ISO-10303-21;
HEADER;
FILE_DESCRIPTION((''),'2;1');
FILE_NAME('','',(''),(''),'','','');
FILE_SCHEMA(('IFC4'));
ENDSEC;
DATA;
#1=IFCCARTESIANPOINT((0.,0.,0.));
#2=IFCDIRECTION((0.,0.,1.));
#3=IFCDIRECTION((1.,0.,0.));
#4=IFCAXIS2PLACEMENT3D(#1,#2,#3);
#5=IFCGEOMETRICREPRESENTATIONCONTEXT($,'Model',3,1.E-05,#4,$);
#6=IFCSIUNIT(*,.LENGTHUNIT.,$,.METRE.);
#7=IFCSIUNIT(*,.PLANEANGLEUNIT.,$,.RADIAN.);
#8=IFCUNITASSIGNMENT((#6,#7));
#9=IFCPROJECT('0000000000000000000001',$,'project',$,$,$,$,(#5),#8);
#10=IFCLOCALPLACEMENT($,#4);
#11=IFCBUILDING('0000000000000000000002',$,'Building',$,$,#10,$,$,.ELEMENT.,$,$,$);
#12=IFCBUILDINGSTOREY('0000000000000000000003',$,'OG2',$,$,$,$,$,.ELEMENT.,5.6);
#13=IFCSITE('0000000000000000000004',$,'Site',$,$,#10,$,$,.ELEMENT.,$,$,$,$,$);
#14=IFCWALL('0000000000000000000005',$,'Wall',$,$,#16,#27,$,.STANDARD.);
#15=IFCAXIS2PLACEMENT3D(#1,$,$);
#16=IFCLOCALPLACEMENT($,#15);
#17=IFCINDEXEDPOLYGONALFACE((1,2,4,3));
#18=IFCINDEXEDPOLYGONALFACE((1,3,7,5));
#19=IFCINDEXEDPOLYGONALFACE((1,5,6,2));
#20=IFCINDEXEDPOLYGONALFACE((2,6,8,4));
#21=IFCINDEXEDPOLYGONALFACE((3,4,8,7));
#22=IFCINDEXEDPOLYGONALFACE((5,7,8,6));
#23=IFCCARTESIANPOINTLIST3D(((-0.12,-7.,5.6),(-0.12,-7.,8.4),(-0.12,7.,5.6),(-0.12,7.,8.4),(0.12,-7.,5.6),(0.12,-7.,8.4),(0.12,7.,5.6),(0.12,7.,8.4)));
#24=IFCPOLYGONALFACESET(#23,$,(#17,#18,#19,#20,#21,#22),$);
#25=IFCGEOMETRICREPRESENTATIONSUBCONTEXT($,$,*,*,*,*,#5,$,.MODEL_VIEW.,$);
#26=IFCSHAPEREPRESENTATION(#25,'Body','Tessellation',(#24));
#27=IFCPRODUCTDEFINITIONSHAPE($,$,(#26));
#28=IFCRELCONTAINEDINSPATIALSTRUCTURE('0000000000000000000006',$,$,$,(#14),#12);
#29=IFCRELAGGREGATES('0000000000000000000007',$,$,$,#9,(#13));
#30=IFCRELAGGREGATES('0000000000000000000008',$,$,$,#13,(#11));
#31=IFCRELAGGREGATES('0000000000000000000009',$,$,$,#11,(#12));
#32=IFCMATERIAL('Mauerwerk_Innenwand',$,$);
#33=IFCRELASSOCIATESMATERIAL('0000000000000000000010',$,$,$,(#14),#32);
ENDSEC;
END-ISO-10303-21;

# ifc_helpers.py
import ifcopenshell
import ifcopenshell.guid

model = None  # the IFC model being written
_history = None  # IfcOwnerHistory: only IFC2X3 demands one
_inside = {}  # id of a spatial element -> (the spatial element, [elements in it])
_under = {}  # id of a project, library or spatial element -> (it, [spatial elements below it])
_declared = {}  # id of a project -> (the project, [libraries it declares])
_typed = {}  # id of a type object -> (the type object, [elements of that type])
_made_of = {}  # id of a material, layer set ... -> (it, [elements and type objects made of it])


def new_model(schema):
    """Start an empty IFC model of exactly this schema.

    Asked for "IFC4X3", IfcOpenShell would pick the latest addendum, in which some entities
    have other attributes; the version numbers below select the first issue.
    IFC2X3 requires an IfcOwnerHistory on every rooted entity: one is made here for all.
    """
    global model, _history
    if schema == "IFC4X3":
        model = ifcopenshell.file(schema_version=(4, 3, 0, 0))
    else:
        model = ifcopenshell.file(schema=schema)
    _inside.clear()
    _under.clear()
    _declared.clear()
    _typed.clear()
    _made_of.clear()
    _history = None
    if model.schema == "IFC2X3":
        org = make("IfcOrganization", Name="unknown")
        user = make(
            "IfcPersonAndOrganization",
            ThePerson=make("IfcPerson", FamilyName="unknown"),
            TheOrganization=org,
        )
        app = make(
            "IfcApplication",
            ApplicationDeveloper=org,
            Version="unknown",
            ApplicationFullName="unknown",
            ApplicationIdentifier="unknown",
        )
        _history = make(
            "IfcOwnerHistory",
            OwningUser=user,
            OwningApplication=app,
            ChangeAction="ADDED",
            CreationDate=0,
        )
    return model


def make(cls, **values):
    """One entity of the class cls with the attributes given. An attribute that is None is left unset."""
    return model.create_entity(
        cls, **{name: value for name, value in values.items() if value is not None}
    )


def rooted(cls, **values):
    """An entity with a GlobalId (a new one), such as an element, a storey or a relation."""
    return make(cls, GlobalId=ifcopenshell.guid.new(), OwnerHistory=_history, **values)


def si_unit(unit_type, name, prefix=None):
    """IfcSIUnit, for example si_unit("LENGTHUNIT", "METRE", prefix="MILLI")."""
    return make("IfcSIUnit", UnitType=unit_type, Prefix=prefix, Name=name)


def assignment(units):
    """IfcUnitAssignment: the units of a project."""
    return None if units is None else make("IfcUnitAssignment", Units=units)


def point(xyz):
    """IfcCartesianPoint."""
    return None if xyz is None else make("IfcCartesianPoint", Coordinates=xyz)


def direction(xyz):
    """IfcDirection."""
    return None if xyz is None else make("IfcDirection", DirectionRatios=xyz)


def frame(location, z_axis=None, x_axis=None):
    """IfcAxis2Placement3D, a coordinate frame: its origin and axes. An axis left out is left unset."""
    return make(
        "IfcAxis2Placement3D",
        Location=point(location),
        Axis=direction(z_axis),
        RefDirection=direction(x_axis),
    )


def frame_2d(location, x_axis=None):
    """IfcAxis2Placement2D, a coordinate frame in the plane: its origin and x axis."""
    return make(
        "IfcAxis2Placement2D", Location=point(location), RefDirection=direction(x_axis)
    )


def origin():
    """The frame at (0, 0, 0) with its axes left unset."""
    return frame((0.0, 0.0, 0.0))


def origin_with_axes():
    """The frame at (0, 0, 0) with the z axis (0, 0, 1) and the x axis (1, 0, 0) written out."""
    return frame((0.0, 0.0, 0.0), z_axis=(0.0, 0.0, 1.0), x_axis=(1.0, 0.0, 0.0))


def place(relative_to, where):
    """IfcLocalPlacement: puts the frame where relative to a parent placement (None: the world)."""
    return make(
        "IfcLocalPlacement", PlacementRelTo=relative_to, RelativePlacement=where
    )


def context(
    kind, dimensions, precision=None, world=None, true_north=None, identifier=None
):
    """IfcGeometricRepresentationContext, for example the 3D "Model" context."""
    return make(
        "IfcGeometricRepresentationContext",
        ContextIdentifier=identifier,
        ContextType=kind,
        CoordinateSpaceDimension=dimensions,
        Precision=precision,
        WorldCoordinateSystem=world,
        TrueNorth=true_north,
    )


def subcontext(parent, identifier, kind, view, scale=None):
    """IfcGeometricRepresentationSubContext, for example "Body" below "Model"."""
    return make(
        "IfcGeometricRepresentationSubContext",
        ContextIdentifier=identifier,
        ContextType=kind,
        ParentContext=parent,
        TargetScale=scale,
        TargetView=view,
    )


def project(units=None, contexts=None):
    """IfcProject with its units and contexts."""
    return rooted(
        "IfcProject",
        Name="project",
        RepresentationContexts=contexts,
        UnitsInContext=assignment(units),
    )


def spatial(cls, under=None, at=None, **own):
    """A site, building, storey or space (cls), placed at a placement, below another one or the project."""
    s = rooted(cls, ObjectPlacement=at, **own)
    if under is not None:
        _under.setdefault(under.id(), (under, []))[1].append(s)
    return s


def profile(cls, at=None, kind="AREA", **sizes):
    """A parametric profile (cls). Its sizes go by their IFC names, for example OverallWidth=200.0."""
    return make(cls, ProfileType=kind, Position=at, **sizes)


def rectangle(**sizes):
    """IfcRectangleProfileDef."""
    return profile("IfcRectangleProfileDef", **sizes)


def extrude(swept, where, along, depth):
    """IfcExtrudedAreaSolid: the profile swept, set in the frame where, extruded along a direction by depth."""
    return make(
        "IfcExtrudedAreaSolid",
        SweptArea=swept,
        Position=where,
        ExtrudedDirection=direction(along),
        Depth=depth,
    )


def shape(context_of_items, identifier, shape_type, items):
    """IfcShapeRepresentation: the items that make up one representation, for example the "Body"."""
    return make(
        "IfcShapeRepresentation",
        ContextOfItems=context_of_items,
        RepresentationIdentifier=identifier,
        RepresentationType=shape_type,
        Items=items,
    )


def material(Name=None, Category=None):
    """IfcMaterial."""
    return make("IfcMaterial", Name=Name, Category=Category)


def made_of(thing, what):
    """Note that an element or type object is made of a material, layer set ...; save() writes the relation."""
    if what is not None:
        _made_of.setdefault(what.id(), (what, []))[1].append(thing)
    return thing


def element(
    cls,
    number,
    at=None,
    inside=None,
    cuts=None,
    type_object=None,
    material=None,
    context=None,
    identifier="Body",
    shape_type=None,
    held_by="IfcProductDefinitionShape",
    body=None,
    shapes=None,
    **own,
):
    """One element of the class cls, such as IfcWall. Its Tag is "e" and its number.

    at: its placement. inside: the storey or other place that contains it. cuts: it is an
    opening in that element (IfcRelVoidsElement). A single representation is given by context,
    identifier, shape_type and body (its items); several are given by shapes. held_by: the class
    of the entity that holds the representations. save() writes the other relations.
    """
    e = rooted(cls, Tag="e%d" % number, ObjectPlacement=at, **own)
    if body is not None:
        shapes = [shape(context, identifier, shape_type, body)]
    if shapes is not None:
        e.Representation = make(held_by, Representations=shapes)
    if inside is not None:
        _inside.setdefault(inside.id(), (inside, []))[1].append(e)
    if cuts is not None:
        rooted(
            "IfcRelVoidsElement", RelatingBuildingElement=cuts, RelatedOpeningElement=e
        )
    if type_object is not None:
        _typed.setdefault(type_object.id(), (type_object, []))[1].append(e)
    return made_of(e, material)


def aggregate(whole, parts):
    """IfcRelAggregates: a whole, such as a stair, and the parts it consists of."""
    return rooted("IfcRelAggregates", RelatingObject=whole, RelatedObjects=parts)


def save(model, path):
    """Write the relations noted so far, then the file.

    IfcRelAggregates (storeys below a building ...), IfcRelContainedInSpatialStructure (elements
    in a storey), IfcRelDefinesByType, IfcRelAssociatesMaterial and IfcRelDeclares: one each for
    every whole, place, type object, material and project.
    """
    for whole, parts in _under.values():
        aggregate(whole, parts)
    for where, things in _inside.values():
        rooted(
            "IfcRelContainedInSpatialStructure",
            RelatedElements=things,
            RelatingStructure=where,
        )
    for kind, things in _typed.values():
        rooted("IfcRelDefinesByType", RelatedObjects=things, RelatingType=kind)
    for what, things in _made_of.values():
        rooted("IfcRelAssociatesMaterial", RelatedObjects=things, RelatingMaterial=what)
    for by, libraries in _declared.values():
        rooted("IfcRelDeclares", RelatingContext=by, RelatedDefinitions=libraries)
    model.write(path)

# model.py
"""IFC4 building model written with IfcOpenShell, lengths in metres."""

from ifc_helpers import new_model, si_unit, frame, frame_2d, origin, origin_with_axes, place, context, subcontext, project, spatial, rectangle, extrude, material, element, save


model = new_model("IFC4")

# Units and contexts
model_context = context("Model", 3, precision=1e-05, world=origin_with_axes())
sub_context = subcontext(model_context, None, None, "MODEL_VIEW")
ifc_project = project(units=[si_unit("LENGTHUNIT", "METRE"), si_unit("PLANEANGLEUNIT", "RADIAN")], contexts=[model_context])

# Site, building, storey
placement_1 = place(None, origin_with_axes())
site = spatial("IfcSite", under=ifc_project, at=placement_1, Name="Site", CompositionType="ELEMENT")
building = spatial("IfcBuilding", under=site, at=placement_1, Name="Building", CompositionType="ELEMENT")
storey = spatial("IfcBuildingStorey", under=building, Name="OG2", CompositionType="ELEMENT", Elevation=5.6)

# Wall
ifc_material = material(Name="Mauerwerk_Innenwand")
placement_2 = place(None, origin_with_axes())
placement_3 = place(placement_2, frame((0.0, 0.0, 5.6)))
wall_placement = place(placement_3, frame((0.0, -7.0, 0.0), x_axis=(0.0, 1.0, 0.0)))
element("IfcWall", 1, at=wall_placement, inside=storey, material=ifc_material, Name="Wall", PredefinedType="STANDARD", context=sub_context, shape_type="SweptSolid", body=[
    extrude(rectangle(XDim=14.0, YDim=0.24, at=frame_2d((7.0, 0.0))), origin(), (0.0, 0.0, 1.0), 2.8),
])

save(model, "model.ifc")
